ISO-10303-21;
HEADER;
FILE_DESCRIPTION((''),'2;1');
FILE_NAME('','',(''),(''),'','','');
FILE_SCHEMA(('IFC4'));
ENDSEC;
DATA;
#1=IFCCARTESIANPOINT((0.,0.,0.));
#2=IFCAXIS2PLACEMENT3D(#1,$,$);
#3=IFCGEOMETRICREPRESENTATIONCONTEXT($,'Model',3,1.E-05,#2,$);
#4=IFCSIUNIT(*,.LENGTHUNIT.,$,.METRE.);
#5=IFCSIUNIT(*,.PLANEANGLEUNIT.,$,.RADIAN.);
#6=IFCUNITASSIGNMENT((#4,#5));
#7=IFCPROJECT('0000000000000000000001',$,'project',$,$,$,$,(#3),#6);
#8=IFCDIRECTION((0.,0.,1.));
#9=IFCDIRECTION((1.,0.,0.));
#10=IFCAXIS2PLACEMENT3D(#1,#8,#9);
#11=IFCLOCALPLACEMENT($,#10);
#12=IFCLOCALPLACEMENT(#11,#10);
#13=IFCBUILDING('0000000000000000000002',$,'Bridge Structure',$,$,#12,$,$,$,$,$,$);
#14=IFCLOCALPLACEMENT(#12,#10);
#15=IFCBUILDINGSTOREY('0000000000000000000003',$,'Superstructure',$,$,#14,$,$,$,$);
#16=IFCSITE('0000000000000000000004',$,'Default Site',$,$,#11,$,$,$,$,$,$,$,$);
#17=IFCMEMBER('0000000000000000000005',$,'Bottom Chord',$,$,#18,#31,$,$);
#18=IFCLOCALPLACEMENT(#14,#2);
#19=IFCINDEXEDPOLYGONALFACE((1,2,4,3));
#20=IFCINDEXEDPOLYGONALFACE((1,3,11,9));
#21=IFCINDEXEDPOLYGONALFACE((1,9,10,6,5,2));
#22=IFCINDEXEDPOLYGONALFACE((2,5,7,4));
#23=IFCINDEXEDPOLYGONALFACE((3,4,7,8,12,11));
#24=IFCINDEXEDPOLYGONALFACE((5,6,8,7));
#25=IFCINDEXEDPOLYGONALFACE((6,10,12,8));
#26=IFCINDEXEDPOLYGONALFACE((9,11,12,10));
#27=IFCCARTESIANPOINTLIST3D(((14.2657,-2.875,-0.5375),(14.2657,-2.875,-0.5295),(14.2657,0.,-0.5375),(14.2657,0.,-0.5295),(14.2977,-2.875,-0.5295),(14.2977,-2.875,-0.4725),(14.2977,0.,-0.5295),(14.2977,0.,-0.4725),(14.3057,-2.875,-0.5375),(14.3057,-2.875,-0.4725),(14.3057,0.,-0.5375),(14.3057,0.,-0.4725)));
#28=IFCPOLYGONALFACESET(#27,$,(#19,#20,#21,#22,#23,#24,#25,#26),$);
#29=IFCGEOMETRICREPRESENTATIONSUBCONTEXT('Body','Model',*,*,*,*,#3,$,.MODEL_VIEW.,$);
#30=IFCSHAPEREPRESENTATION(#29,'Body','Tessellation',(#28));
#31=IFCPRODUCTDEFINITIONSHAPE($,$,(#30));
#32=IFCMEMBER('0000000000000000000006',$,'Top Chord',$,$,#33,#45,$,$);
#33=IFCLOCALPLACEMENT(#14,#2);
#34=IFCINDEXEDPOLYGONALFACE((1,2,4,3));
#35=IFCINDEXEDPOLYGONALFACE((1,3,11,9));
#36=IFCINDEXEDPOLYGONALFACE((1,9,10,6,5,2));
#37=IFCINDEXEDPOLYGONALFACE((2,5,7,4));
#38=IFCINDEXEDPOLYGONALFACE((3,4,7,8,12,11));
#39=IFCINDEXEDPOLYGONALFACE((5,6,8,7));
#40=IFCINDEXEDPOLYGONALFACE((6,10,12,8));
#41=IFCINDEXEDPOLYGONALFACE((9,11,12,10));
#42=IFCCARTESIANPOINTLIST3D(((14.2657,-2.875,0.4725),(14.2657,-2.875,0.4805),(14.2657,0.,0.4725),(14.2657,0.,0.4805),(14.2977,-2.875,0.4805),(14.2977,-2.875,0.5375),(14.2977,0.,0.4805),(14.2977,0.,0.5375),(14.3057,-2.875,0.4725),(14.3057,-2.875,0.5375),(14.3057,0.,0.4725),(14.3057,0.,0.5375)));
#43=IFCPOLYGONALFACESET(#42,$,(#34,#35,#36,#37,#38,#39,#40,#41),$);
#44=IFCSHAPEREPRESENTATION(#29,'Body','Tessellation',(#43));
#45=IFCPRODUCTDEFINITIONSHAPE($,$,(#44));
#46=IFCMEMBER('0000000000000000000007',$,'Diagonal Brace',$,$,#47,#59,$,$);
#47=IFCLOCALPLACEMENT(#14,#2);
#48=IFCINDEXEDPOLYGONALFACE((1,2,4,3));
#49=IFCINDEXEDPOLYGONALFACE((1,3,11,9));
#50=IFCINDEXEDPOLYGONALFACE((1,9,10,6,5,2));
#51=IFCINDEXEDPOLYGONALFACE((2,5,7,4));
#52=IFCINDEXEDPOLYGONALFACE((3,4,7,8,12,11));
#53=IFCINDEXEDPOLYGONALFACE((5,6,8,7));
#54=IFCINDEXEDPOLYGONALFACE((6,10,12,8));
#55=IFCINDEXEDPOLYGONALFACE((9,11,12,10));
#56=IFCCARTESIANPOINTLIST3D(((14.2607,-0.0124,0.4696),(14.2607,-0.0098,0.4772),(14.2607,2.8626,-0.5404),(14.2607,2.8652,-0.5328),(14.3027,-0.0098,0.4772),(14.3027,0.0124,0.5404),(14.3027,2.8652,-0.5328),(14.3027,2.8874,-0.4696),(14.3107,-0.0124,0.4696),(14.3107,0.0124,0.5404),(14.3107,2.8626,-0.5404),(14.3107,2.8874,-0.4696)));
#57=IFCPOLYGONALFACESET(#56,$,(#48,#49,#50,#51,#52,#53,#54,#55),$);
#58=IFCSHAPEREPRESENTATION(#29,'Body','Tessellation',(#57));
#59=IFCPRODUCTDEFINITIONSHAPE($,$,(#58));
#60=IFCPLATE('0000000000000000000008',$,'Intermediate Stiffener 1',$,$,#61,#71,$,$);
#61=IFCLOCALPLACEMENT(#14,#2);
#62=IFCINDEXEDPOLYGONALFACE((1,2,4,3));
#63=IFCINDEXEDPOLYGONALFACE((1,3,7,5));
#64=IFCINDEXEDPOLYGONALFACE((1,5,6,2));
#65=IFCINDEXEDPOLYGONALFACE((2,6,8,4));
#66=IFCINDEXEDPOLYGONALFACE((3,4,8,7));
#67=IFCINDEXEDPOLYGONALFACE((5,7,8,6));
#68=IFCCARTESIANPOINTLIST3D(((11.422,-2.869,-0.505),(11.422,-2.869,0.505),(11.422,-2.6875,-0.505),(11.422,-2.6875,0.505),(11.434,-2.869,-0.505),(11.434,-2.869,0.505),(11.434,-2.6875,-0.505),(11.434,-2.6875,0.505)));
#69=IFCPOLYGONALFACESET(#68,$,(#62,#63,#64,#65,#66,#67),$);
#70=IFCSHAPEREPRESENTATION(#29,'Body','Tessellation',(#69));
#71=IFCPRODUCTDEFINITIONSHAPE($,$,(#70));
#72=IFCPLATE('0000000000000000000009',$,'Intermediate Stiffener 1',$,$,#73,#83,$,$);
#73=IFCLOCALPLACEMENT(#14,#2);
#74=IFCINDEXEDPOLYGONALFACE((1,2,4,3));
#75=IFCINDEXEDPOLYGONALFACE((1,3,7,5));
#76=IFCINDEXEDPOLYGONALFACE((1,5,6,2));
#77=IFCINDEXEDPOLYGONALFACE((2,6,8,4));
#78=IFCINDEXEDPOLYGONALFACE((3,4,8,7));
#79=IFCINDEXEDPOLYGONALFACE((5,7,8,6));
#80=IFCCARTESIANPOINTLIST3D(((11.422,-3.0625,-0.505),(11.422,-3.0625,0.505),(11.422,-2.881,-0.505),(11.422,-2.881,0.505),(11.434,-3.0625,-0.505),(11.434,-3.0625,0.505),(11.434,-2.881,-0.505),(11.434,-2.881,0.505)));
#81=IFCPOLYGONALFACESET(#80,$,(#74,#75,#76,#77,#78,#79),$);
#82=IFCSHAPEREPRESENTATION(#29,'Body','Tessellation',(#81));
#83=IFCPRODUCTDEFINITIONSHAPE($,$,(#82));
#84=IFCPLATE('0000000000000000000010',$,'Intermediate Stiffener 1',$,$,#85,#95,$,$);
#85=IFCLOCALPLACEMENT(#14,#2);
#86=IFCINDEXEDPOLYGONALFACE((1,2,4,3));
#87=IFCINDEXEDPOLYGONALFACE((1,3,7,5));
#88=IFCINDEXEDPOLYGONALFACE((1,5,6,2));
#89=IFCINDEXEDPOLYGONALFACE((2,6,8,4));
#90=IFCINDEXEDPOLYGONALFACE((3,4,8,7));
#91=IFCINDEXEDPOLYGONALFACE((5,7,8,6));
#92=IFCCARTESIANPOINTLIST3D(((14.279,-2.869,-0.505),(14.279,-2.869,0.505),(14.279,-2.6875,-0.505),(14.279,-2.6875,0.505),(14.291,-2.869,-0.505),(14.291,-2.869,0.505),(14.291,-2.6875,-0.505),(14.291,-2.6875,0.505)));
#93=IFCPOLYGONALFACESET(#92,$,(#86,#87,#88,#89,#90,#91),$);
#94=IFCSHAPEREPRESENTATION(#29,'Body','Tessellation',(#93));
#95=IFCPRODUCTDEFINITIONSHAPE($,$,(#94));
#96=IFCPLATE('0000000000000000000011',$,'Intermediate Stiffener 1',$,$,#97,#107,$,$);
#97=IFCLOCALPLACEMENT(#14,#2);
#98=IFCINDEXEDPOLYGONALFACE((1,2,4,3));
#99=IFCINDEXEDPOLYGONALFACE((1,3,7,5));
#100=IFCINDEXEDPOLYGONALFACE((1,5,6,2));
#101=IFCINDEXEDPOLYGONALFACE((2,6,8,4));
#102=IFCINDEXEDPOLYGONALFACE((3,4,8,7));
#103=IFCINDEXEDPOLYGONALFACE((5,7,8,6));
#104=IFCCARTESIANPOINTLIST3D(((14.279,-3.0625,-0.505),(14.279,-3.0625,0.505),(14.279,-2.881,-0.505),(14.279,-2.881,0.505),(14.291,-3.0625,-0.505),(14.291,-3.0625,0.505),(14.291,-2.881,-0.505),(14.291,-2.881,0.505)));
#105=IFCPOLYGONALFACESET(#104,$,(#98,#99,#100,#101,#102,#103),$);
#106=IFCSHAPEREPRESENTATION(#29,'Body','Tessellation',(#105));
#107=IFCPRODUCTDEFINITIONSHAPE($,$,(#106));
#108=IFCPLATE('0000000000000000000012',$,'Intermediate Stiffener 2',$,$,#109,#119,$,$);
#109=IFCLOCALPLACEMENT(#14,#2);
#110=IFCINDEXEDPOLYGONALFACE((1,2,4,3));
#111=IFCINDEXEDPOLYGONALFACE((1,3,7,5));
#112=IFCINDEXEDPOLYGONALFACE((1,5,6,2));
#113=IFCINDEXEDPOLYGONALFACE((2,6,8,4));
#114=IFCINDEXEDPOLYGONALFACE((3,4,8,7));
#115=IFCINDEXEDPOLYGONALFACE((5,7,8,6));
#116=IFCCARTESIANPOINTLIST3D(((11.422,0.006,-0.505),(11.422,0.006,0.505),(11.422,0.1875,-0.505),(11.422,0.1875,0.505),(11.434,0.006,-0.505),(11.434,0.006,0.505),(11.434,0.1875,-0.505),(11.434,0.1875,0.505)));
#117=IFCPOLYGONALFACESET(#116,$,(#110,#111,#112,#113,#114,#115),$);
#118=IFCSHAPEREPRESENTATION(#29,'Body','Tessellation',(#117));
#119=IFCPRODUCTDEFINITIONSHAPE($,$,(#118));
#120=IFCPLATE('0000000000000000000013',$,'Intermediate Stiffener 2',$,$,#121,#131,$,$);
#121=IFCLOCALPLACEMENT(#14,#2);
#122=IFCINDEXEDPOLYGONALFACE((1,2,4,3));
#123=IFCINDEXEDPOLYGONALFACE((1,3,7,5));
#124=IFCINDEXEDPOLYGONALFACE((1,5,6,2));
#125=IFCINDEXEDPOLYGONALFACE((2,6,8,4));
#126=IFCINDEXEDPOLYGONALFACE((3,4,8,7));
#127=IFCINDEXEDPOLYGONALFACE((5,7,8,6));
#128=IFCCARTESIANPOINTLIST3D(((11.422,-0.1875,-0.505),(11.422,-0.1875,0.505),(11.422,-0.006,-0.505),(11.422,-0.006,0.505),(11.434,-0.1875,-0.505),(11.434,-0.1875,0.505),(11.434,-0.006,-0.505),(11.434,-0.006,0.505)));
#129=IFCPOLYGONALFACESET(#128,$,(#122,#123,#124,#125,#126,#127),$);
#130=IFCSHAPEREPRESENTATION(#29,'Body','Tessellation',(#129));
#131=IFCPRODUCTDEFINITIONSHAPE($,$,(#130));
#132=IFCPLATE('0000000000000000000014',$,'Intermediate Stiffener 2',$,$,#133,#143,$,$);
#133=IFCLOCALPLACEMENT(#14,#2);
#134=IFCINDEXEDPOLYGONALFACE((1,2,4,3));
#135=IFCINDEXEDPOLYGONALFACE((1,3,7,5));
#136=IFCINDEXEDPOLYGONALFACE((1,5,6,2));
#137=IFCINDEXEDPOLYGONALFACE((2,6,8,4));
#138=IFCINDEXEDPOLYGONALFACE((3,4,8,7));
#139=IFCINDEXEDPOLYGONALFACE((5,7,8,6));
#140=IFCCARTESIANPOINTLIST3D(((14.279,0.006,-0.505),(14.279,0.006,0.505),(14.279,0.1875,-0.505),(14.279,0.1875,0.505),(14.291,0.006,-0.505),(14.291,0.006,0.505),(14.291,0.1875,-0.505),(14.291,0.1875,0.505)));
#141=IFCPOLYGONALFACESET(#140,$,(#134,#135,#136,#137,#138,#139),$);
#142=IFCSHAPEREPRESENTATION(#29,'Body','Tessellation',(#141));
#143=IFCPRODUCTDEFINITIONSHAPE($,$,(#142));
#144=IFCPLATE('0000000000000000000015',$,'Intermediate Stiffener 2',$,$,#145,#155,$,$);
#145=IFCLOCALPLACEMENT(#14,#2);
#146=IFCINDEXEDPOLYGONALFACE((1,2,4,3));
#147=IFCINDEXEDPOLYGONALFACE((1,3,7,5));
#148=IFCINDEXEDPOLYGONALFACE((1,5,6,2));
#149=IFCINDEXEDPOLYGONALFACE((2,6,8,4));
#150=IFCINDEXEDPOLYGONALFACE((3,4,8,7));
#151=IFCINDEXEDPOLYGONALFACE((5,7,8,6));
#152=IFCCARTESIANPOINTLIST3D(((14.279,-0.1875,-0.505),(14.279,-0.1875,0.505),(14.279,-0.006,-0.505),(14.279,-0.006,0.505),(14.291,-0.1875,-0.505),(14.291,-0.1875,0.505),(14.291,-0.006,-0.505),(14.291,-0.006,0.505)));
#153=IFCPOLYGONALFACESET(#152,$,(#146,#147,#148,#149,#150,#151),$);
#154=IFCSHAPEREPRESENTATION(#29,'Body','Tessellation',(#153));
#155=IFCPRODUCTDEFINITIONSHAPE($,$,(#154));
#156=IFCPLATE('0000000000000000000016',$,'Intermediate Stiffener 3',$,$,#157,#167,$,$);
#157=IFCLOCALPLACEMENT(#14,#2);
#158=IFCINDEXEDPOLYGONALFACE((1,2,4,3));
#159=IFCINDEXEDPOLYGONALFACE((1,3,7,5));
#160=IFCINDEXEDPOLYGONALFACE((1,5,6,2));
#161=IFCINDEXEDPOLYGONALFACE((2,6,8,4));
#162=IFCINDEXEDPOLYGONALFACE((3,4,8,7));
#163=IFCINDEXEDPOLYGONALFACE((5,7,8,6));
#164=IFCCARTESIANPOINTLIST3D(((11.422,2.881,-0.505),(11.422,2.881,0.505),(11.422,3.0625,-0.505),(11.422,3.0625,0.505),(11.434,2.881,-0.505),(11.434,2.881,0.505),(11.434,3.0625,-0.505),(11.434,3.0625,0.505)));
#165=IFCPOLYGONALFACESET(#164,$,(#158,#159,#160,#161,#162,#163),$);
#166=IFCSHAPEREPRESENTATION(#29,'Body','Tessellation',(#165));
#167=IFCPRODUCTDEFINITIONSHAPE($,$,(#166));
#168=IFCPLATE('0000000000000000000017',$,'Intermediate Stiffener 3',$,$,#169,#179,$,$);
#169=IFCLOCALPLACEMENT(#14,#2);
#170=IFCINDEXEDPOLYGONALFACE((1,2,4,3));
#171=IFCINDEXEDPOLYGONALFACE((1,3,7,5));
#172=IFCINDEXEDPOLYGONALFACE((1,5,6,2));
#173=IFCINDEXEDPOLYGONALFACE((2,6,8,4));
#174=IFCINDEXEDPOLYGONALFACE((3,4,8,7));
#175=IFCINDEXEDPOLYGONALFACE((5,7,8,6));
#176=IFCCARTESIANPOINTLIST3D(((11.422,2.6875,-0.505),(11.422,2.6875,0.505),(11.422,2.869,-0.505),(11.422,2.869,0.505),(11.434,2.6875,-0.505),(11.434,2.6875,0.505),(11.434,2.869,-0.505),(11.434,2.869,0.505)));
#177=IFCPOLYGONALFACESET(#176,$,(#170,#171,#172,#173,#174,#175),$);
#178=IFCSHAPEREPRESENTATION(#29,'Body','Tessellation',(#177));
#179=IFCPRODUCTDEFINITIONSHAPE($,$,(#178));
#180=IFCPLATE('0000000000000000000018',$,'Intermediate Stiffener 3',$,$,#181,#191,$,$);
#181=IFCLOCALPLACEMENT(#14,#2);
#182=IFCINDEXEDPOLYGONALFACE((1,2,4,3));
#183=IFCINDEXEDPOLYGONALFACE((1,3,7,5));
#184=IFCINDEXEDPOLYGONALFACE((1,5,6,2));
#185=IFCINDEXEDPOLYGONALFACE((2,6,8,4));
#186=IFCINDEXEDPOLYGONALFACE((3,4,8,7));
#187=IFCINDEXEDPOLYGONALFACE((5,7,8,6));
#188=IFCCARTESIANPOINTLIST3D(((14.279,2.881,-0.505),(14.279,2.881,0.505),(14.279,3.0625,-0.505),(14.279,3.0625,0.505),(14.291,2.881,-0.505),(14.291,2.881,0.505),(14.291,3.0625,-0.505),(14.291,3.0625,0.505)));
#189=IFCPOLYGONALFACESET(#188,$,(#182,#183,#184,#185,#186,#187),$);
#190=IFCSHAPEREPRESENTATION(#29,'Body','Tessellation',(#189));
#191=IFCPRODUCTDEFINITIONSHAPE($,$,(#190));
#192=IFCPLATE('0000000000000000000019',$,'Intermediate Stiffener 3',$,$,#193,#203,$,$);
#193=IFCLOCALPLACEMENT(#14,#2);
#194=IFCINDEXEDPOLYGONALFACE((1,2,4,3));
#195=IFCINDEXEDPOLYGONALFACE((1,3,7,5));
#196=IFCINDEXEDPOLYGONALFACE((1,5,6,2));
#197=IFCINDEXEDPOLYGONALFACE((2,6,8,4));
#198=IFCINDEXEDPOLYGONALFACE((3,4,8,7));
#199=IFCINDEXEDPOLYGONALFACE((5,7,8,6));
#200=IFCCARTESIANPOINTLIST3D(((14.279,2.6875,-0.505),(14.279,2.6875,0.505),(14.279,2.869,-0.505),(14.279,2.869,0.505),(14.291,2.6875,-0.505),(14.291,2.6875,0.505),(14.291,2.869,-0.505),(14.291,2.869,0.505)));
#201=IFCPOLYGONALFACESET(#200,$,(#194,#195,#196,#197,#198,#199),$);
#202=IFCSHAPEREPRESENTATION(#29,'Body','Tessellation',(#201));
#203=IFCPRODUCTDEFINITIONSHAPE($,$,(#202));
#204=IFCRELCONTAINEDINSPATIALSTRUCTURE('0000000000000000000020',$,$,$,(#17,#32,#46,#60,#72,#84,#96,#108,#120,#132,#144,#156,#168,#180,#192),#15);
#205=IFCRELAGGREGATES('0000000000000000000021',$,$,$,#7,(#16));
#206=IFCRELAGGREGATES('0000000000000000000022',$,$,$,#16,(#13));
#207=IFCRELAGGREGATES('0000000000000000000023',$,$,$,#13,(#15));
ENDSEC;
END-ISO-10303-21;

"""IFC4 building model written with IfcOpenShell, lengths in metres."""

from ifc_helpers import new_model, si_unit, frame, origin, origin_with_axes, origin_2d_with_axis, place, context, subcontext, project, spatial, rectangle, l_section, extrude, element, save


model = new_model("IFC4")

# Units and contexts
model_context = context("Model", 3, precision=1e-05, world=origin())
body_context = subcontext(model_context, "Body", "Model", "MODEL_VIEW")
ifc_project = project(units=[si_unit("LENGTHUNIT", "METRE"), si_unit("PLANEANGLEUNIT", "RADIAN")], contexts=[model_context])

# Site, building, storey
site_placement = place(None, origin_with_axes())
site = spatial("IfcSite", under=ifc_project, at=site_placement, Name="Default Site")
building_placement = place(site_placement, origin_with_axes())
building = spatial("IfcBuilding", under=site, at=building_placement, Name="Bridge Structure")
storey_placement = place(building_placement, origin_with_axes())
storey = spatial("IfcBuildingStorey", under=building, at=storey_placement, Name="Superstructure")

# Members
for number, where, z_axis, x_axis, name in (
    (1, (14.2857, -2.875, -0.505), (0.0, 1.0, 0.0), (-1.0, 0.0, 0.0), "Bottom Chord"),
    (2, (14.2857, -2.875, 0.505), (0.0, 1.0, 0.0), (-1.0, 0.0, 0.0), "Top Chord"),
):
    element("IfcMember", number, at=place(storey_placement, frame(where, z_axis=z_axis, x_axis=x_axis)), inside=storey, Name=name, context=body_context, shape_type="SweptSolid", body=[
        extrude(l_section(Depth=0.065, Width=0.04, Thickness=0.008, at=origin_2d_with_axis()), origin_with_axes(), (0.0, 0.0, 1.0), 2.875),
    ])
member_1_placement = place(storey_placement, frame((14.2857, 0.0, 0.505), z_axis=(0.0, 0.943474, -0.331447), x_axis=(-1.0, 0.0, 0.0)))
element("IfcMember", 3, at=member_1_placement, inside=storey, Name="Diagonal Brace", context=body_context, shape_type="SweptSolid", body=[
    extrude(l_section(Depth=0.075, Width=0.05, Thickness=0.008, at=origin_2d_with_axis()), origin_with_axes(), (0.0, 0.0, 1.0), 3.0472),
])

# Plates
for number, where, z_axis, x_axis, name in (
    (4, (11.428, -2.7782, -0.505), (0.0, 0.0, 1.0), (1.0, 0.0, 0.0), "Intermediate Stiffener 1"),
    (5, (11.428, -2.9718, -0.505), (0.0, 0.0, 1.0), (1.0, 0.0, 0.0), "Intermediate Stiffener 1"),
    (6, (14.285, -2.7782, -0.505), (0.0, 0.0, 1.0), (1.0, 0.0, 0.0), "Intermediate Stiffener 1"),
    (7, (14.285, -2.9718, -0.505), (0.0, 0.0, 1.0), (1.0, 0.0, 0.0), "Intermediate Stiffener 1"),
    (8, (11.428, 0.0968, -0.505), (0.0, 0.0, 1.0), (1.0, 0.0, 0.0), "Intermediate Stiffener 2"),
    (9, (11.428, -0.0968, -0.505), (0.0, 0.0, 1.0), (1.0, 0.0, 0.0), "Intermediate Stiffener 2"),
    (10, (14.285, 0.0968, -0.505), (0.0, 0.0, 1.0), (1.0, 0.0, 0.0), "Intermediate Stiffener 2"),
    (11, (14.285, -0.0968, -0.505), (0.0, 0.0, 1.0), (1.0, 0.0, 0.0), "Intermediate Stiffener 2"),
    (12, (11.428, 2.9718, -0.505), (0.0, 0.0, 1.0), (1.0, 0.0, 0.0), "Intermediate Stiffener 3"),
    (13, (11.428, 2.7782, -0.505), (0.0, 0.0, 1.0), (1.0, 0.0, 0.0), "Intermediate Stiffener 3"),
    (14, (14.285, 2.9718, -0.505), (0.0, 0.0, 1.0), (1.0, 0.0, 0.0), "Intermediate Stiffener 3"),
    (15, (14.285, 2.7782, -0.505), (0.0, 0.0, 1.0), (1.0, 0.0, 0.0), "Intermediate Stiffener 3"),
):
    element("IfcPlate", number, at=place(storey_placement, frame(where, z_axis=z_axis, x_axis=x_axis)), inside=storey, Name=name, context=body_context, shape_type="SweptSolid", body=[
        extrude(rectangle(XDim=0.012, YDim=0.1815, at=origin_2d_with_axis()), origin_with_axes(), (0.0, 0.0, 1.0), 1.01),
    ])

save(model, "model.ifc")
